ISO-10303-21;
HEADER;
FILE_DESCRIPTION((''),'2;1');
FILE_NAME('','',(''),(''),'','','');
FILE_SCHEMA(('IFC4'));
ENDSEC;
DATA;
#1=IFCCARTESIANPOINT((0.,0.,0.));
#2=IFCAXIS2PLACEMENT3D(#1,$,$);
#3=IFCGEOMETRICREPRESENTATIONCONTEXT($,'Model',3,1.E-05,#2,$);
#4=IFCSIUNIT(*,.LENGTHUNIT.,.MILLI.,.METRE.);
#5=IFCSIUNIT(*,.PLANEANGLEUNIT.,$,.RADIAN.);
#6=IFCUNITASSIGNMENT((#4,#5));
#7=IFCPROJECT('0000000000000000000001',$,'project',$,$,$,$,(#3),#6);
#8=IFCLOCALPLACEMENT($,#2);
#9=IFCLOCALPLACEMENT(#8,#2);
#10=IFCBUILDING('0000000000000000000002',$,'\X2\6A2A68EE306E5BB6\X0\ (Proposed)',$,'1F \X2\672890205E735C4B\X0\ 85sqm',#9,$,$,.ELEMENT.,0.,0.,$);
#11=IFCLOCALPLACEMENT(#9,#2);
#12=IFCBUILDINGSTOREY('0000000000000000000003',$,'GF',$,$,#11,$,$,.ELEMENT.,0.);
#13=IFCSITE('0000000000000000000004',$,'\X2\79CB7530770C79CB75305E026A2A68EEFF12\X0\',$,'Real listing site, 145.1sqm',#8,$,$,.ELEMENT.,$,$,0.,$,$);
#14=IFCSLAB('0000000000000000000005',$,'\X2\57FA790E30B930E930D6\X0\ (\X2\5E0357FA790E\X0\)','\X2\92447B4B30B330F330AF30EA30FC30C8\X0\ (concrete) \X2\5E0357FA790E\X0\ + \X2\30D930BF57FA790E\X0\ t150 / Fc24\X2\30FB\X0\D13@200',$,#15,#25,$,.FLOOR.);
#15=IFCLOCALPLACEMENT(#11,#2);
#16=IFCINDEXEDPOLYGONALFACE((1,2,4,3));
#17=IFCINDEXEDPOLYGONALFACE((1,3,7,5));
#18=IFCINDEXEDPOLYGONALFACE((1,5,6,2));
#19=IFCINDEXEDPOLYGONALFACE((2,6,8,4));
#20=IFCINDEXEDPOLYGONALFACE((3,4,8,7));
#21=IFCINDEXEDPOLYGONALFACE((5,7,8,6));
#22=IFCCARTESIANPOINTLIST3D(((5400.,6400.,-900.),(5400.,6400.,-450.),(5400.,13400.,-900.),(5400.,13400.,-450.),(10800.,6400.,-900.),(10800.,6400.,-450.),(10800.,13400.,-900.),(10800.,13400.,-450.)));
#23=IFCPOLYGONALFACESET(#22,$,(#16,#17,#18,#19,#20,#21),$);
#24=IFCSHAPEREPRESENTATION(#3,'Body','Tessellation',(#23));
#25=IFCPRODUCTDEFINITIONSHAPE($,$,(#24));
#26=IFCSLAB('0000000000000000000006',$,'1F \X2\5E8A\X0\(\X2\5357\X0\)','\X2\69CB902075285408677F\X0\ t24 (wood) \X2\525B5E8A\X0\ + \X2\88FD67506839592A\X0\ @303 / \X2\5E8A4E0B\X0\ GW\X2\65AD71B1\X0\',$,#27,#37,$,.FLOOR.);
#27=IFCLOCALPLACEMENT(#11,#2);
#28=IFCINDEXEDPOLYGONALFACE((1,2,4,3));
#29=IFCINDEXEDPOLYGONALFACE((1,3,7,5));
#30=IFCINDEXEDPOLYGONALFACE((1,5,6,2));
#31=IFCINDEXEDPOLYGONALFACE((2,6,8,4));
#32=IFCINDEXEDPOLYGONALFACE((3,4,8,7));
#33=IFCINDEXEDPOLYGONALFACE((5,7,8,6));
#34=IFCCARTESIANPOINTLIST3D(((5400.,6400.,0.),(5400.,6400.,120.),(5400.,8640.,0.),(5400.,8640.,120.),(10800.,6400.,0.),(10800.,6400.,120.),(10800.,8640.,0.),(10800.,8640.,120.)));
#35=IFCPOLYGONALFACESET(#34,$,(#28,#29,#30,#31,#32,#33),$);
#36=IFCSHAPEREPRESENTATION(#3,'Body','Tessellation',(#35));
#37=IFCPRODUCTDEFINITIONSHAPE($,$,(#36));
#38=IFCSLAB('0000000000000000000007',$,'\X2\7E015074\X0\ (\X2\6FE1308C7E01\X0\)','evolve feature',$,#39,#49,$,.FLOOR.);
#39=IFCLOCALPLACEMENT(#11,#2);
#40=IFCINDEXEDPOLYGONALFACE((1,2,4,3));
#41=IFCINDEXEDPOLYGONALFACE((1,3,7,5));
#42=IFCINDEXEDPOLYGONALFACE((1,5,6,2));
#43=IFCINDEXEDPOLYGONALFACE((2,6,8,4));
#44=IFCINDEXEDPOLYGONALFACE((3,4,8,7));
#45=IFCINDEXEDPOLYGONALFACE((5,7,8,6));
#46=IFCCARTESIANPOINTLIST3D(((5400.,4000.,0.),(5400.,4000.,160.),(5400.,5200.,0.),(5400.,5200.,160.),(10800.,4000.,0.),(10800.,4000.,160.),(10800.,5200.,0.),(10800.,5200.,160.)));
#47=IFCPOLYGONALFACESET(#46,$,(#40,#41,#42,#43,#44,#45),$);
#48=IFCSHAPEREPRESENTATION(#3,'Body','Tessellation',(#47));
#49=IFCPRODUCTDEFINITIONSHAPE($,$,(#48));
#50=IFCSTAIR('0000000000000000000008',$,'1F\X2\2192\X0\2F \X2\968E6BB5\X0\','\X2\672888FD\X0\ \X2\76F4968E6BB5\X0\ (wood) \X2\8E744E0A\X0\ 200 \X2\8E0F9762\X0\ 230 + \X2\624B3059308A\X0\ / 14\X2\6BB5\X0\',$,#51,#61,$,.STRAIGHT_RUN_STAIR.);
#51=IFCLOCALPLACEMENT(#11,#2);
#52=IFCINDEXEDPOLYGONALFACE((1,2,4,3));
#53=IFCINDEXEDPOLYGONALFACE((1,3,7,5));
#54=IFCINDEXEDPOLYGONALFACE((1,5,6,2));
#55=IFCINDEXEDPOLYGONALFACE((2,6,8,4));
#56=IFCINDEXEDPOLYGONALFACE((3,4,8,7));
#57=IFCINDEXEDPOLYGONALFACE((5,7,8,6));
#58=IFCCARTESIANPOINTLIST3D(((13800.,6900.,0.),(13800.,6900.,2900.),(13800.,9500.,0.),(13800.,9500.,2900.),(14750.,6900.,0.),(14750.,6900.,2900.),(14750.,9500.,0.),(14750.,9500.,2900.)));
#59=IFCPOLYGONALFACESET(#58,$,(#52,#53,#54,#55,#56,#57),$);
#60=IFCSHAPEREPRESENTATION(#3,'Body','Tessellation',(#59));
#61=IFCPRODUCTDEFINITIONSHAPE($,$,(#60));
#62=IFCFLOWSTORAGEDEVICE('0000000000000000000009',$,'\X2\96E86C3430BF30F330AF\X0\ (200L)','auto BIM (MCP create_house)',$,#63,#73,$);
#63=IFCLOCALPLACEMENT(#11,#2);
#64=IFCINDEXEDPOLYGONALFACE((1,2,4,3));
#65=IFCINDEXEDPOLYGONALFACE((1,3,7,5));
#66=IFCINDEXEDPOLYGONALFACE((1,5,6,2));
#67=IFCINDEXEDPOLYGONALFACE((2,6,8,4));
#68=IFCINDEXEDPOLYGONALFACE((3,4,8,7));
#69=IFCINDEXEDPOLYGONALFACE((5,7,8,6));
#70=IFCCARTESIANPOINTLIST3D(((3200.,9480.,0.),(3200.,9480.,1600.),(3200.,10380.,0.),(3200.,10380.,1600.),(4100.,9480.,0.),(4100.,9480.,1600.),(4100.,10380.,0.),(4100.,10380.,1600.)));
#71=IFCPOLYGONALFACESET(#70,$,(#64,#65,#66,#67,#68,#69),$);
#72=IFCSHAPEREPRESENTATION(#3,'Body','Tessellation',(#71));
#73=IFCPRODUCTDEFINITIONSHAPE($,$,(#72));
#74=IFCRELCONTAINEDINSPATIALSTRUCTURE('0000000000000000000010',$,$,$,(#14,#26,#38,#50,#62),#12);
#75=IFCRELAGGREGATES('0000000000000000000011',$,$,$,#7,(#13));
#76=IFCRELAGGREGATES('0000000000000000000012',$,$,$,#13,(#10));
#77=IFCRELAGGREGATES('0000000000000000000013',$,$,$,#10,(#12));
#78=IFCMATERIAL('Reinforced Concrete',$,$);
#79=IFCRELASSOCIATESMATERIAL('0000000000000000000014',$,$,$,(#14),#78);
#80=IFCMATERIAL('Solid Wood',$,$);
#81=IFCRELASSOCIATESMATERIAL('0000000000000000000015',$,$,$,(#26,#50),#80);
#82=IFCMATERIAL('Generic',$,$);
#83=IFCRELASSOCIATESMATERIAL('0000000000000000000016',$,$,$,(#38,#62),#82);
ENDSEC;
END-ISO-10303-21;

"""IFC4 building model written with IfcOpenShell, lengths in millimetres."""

from ifc_helpers import new_model, si_unit, frame, frame_2d, origin, place, context, project, spatial, rectangle, extrude, material, element, save


model = new_model("IFC4")

# Units and contexts
model_context = context("Model", 3, precision=1e-05, world=origin())
ifc_project = project(units=[si_unit("LENGTHUNIT", "METRE", prefix="MILLI"), si_unit("PLANEANGLEUNIT", "RADIAN")], contexts=[model_context])

# Site, building, storey
site_placement = place(None, origin())
site = spatial("IfcSite", under=ifc_project, at=site_placement, Name="秋田県秋田市横森２", ObjectType="Real listing site, 145.1sqm", CompositionType="ELEMENT", RefElevation=0.0)
building_placement = place(site_placement, origin())
building = spatial("IfcBuilding", under=site, at=building_placement, Name="横森の家 (Proposed)", ObjectType="1F 木造平屋 85sqm", CompositionType="ELEMENT", ElevationOfRefHeight=0.0, ElevationOfTerrain=0.0)
storey_placement = place(building_placement, origin())
storey = spatial("IfcBuildingStorey", under=building, at=storey_placement, Name="GF", CompositionType="ELEMENT", Elevation=0.0)

# Slabs
ifc_material_1 = material(Name="Reinforced Concrete")
slab_1_placement = place(storey_placement, frame((2700.0, 3200.0, -450.0)))
element("IfcSlab", 1, at=slab_1_placement, inside=storey, material=ifc_material_1, Name="基礎スラブ (布基礎)", Description="鉄筋コンクリート (concrete) 布基礎 + ベタ基礎 t150 / Fc24・D13@200", PredefinedType="FLOOR", context=model_context, shape_type="SweptSolid", body=[
    extrude(rectangle(XDim=5400.0, YDim=7000.0, at=frame_2d((2700.0, 3500.0))), frame((2700.0, 3200.0, -450.0)), (0.0, 0.0, 1.0), 450.0),
])
ifc_material_2 = material(Name="Solid Wood")
slab_2_placement = place(storey_placement, frame((2700.0, 3200.0, 0.0)))
element("IfcSlab", 2, at=slab_2_placement, inside=storey, material=ifc_material_2, Name="1F 床(南)", Description="構造用合板 t24 (wood) 剛床 + 製材根太 @303 / 床下 GW断熱", PredefinedType="FLOOR", context=model_context, shape_type="SweptSolid", body=[
    extrude(rectangle(XDim=5400.0, YDim=2240.0, at=frame_2d((2700.0, 1120.0))), frame((2700.0, 3200.0, 0.0)), (0.0, 0.0, 1.0), 120.0),
])
ifc_material_3 = material(Name="Generic")
slab_3_placement = place(storey_placement, frame((2700.0, 2000.0, 0.0)))
element("IfcSlab", 3, at=slab_3_placement, inside=storey, material=ifc_material_3, Name="縁側 (濡れ縁)", Description="evolve feature", PredefinedType="FLOOR", context=model_context, shape_type="SweptSolid", body=[
    extrude(rectangle(XDim=5400.0, YDim=1200.0, at=frame_2d((2700.0, 600.0))), frame((2700.0, 2000.0, 0.0)), (0.0, 0.0, 1.0), 160.0),
])

# Stair
stair_placement = place(storey_placement, frame((6900.0, 3450.0, 0.0)))
element("IfcStair", 4, at=stair_placement, inside=storey, material=ifc_material_2, Name="1F→2F 階段", Description="木製 直階段 (wood) 蹴上 200 踏面 230 + 手すり / 14段", PredefinedType="STRAIGHT_RUN_STAIR", context=model_context, shape_type="SweptSolid", body=[
    extrude(rectangle(XDim=950.0, YDim=2600.0, at=frame_2d((475.0, 1300.0))), frame((6900.0, 3450.0, 0.0)), (0.0, 0.0, 1.0), 2900.0),
])

# Flow storage device
flow_storage_device_placement = place(storey_placement, frame((1600.0, 4740.0, 0.0)))
element("IfcFlowStorageDevice", 5, at=flow_storage_device_placement, inside=storey, material=ifc_material_3, Name="雨水タンク (200L)", Description="auto BIM (MCP create_house)", context=model_context, shape_type="SweptSolid", body=[
    extrude(rectangle(XDim=900.0, YDim=900.0, at=frame_2d((450.0, 450.0))), frame((1600.0, 4740.0, 0.0)), (0.0, 0.0, 1.0), 1600.0),
])

save(model, "model.ifc")
